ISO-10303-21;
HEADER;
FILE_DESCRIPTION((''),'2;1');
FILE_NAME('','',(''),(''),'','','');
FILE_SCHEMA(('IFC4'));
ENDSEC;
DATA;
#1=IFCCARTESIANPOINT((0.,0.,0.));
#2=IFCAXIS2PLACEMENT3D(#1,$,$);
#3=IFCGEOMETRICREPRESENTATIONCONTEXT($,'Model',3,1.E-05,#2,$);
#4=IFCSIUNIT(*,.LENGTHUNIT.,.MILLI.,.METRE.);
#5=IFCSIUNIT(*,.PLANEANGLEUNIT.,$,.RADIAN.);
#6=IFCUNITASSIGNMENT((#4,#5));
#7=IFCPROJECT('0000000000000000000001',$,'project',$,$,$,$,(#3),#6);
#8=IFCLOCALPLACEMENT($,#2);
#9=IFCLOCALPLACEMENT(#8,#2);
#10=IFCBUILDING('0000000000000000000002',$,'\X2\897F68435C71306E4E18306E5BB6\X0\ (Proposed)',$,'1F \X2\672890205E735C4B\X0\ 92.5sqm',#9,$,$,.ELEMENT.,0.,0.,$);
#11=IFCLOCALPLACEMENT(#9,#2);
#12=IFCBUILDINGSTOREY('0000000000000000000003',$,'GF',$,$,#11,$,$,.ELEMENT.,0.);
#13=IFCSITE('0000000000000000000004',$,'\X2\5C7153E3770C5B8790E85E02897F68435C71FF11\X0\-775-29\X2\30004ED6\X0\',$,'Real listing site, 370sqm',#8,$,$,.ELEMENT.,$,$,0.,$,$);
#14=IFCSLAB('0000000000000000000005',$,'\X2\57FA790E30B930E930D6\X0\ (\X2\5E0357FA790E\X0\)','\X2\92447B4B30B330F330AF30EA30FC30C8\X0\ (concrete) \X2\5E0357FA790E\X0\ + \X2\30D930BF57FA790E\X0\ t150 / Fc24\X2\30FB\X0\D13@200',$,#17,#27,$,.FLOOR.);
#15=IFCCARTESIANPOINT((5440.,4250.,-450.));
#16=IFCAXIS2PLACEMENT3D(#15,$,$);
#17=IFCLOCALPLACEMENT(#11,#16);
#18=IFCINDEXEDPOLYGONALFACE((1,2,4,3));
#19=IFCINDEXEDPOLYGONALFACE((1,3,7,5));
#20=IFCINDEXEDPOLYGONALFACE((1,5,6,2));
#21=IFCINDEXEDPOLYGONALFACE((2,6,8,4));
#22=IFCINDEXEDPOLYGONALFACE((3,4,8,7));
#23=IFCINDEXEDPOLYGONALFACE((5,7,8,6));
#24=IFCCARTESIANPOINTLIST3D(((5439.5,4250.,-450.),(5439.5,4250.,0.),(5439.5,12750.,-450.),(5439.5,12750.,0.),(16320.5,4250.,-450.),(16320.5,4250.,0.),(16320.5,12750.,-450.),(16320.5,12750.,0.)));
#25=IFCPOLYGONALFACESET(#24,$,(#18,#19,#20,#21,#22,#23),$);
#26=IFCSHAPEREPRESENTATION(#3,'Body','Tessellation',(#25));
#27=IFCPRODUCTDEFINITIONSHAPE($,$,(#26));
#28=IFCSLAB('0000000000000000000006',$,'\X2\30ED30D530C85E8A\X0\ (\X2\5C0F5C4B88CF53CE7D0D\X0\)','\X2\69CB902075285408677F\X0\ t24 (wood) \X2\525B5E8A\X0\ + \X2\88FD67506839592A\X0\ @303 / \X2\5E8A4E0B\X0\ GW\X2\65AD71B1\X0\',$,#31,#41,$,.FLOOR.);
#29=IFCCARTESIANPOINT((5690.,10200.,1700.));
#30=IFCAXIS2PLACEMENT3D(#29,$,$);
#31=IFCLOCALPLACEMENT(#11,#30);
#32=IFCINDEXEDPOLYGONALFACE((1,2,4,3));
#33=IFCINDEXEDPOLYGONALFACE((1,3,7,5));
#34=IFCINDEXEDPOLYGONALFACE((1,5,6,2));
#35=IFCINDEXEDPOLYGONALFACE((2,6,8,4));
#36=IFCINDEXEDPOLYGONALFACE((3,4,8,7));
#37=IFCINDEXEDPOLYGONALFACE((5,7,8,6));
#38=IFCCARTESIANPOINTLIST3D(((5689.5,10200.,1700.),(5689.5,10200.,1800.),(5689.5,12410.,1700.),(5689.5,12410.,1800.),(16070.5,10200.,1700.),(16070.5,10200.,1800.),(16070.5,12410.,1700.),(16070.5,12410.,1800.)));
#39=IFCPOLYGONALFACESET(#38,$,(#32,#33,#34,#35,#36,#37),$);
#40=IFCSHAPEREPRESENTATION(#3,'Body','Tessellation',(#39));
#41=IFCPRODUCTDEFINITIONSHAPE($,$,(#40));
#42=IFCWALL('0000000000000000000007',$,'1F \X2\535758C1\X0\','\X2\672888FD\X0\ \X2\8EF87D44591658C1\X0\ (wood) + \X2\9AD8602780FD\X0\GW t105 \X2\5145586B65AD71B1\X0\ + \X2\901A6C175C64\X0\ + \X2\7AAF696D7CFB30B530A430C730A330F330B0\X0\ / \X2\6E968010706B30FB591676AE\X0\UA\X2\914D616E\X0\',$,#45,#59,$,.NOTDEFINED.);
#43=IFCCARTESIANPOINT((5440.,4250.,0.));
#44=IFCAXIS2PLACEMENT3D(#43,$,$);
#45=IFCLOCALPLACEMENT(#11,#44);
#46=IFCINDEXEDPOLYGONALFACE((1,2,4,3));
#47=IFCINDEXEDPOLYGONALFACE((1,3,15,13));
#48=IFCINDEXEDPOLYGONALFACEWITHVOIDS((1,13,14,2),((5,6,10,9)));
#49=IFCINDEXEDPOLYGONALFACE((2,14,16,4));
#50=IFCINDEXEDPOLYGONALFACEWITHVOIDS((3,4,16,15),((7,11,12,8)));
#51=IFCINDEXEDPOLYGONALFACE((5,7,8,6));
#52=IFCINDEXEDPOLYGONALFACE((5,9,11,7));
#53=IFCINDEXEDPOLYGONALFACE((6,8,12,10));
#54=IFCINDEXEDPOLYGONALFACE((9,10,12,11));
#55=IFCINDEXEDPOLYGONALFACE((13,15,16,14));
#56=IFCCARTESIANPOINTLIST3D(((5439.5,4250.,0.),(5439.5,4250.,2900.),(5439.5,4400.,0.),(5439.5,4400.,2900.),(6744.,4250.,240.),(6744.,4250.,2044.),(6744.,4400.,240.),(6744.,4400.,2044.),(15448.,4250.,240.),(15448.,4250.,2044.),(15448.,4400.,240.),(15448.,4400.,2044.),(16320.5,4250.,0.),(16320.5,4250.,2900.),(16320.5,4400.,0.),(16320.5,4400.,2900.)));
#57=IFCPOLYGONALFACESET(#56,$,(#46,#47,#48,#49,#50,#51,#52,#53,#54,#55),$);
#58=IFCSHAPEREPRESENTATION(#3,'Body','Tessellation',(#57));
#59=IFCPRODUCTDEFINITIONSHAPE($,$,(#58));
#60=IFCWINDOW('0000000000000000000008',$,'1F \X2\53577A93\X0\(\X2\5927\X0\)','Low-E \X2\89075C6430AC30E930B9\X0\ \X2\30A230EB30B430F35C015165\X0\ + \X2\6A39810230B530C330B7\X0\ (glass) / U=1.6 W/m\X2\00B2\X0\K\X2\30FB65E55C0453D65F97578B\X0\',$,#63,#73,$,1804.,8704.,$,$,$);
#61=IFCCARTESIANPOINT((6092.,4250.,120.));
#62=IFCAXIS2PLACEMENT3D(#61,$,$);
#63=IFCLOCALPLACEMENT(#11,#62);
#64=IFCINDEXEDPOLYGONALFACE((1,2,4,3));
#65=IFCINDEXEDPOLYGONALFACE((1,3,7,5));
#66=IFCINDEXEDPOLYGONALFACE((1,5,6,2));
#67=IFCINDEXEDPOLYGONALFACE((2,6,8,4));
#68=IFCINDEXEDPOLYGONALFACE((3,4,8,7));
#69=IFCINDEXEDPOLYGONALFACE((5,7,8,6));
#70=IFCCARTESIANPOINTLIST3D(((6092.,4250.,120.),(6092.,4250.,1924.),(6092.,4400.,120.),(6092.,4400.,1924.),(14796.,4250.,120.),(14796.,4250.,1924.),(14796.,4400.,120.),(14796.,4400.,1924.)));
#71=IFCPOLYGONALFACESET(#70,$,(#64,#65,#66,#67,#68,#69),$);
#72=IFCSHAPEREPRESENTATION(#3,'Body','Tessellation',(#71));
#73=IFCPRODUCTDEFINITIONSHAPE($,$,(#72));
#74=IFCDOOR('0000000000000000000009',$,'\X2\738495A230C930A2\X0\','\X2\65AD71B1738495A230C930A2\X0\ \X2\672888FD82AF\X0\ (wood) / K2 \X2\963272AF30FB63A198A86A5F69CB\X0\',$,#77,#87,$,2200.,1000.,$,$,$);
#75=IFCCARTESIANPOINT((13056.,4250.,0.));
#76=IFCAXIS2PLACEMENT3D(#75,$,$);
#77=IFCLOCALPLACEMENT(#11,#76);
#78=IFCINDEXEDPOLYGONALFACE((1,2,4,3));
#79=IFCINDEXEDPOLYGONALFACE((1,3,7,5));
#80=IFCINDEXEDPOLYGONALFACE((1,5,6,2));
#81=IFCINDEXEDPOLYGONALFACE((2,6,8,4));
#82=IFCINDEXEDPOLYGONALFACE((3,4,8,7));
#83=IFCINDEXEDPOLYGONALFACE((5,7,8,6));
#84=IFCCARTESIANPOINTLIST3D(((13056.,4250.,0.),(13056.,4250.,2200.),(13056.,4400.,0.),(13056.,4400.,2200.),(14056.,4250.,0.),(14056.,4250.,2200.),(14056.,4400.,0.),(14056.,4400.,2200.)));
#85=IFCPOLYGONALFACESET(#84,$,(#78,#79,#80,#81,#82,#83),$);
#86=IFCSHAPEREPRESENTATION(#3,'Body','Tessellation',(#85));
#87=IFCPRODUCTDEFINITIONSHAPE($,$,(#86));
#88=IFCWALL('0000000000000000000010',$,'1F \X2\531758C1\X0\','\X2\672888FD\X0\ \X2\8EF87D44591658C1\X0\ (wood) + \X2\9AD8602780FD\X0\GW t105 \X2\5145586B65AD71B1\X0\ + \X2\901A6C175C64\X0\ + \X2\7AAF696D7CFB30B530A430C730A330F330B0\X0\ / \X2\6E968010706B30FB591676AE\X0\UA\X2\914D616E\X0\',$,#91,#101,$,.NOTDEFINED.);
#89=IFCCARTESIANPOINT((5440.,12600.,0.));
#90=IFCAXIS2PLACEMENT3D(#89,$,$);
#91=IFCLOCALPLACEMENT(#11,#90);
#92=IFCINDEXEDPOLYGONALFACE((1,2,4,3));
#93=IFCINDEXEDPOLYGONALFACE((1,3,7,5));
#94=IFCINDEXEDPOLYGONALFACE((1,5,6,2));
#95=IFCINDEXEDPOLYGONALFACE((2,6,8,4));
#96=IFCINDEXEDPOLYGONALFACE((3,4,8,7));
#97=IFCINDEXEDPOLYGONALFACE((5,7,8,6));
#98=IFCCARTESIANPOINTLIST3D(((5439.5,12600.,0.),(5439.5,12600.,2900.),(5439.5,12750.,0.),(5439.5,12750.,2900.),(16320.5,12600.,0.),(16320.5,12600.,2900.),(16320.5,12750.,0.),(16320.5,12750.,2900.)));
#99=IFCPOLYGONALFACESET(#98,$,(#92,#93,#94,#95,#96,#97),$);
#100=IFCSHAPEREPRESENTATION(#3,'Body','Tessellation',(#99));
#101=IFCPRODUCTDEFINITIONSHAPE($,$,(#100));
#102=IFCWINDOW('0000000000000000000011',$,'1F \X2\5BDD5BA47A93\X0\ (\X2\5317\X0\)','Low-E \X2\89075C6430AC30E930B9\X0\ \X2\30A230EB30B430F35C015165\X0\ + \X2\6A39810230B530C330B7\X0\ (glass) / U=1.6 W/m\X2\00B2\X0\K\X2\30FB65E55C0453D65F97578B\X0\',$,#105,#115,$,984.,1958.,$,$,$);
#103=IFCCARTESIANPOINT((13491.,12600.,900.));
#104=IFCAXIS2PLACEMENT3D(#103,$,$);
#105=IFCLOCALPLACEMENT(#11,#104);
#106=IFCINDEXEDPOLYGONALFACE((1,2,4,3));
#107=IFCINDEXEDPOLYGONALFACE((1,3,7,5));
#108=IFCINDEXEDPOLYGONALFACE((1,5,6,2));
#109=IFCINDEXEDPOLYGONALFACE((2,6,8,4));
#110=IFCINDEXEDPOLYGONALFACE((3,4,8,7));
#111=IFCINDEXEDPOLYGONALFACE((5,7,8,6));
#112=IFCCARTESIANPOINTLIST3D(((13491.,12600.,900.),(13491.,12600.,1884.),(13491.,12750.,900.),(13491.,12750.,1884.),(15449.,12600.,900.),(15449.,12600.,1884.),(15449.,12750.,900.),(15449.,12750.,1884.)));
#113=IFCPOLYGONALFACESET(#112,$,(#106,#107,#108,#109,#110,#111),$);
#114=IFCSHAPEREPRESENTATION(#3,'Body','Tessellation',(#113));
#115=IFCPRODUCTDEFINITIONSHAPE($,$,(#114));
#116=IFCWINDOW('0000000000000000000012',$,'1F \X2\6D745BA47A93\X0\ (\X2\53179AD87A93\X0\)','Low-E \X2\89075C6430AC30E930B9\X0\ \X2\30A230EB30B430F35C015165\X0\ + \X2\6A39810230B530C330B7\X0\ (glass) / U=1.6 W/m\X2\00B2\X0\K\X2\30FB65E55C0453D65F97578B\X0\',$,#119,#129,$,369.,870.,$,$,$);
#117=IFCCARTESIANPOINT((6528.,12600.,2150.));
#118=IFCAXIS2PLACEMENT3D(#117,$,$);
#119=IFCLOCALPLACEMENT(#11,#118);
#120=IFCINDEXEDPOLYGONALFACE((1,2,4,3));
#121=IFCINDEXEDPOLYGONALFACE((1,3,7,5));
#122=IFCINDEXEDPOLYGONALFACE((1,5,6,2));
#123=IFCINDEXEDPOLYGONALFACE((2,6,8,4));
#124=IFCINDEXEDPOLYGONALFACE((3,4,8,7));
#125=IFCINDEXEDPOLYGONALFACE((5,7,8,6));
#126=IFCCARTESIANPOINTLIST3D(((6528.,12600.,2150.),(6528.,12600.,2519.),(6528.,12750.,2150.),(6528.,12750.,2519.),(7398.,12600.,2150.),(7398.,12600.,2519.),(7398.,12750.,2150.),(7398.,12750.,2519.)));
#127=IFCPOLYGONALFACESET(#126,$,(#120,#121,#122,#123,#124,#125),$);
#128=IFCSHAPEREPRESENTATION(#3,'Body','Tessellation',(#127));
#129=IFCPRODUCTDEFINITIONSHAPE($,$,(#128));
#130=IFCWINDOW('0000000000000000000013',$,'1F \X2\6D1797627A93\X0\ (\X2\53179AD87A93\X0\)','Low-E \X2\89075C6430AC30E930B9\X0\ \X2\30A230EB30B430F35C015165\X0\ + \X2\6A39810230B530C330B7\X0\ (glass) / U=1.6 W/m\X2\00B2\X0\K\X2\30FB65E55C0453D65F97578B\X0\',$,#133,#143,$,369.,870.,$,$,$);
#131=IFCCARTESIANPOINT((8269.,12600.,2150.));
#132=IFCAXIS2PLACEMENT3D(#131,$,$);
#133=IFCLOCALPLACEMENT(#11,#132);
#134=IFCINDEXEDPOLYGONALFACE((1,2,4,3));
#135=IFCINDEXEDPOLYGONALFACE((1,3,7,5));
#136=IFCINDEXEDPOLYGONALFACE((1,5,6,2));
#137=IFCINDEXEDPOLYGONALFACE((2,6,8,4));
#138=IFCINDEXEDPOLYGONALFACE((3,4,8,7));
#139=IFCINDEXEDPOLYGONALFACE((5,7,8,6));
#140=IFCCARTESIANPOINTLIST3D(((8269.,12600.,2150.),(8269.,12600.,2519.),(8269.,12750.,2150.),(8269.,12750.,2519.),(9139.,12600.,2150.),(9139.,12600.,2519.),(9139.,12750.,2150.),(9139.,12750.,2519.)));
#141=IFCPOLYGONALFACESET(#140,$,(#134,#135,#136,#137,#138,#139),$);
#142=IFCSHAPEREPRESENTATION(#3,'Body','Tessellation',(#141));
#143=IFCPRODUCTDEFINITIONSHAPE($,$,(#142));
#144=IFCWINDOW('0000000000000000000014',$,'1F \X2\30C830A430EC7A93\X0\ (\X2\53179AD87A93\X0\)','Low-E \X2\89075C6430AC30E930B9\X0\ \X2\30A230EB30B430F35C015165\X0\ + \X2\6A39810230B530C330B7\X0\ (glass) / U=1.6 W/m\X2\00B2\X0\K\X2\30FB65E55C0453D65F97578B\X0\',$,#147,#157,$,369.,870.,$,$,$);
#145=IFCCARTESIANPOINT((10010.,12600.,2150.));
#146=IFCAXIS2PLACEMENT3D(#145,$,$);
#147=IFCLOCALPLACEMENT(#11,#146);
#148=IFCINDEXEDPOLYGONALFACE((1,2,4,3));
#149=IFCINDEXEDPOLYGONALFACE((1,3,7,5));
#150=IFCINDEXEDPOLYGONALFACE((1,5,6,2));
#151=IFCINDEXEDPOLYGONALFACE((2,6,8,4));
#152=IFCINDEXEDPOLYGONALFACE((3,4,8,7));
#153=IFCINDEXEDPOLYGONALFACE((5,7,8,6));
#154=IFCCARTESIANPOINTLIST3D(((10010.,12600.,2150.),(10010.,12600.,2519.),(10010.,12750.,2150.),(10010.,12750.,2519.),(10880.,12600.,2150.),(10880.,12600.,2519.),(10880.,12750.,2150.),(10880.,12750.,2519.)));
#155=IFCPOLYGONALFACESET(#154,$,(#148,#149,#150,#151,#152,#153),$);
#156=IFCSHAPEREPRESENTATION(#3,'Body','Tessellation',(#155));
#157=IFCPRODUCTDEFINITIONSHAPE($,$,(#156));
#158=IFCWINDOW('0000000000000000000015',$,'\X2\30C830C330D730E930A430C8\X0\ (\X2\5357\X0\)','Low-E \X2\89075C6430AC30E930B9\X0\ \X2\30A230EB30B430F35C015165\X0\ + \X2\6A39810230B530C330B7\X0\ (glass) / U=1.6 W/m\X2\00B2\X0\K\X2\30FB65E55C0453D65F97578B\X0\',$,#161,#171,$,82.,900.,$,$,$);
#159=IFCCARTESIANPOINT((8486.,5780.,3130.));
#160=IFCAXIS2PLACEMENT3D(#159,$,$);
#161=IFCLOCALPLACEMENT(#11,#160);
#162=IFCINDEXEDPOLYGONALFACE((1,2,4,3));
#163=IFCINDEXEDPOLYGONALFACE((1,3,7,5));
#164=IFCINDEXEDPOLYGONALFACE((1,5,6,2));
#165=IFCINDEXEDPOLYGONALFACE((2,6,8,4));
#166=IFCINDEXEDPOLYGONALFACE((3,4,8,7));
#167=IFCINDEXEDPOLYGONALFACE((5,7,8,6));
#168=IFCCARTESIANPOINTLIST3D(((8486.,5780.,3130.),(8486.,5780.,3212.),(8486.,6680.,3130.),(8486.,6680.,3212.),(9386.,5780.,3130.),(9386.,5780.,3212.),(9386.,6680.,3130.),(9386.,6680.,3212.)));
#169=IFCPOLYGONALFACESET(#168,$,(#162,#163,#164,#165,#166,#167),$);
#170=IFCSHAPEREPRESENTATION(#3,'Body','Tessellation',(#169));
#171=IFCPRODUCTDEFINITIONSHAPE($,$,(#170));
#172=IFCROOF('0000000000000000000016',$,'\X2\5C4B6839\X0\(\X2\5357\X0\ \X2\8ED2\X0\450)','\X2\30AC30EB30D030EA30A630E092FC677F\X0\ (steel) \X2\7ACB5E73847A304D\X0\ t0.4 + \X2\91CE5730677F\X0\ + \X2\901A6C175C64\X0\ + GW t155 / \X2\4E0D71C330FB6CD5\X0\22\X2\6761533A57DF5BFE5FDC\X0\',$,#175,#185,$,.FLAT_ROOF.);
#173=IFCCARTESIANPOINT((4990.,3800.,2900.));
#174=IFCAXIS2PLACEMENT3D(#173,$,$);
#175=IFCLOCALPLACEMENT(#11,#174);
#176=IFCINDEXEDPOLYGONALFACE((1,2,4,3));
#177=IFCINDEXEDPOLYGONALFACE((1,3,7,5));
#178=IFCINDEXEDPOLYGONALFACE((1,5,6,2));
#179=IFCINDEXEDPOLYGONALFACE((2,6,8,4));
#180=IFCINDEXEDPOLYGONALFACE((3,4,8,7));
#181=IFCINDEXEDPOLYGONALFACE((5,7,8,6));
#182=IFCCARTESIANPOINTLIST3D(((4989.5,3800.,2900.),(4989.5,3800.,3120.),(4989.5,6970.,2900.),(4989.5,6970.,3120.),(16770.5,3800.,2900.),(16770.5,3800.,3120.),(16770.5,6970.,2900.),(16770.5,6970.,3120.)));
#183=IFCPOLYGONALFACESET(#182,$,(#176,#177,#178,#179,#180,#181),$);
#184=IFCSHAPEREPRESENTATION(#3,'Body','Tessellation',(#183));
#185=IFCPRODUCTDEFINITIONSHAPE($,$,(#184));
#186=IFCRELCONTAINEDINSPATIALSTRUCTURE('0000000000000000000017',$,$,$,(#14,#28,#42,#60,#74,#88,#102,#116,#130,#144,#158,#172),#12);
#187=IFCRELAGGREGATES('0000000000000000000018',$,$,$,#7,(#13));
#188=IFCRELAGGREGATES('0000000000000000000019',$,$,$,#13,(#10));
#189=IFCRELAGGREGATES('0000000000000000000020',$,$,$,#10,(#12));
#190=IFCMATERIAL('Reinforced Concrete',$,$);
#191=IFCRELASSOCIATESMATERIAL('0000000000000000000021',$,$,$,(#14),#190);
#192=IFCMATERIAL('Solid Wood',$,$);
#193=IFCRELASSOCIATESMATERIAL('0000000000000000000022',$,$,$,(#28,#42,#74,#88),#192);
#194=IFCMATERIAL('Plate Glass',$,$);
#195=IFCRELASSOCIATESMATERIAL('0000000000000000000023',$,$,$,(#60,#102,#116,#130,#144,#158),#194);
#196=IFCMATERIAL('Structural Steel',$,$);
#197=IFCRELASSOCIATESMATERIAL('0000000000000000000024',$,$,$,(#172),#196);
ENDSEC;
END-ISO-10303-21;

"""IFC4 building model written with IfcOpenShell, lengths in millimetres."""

from ifc_helpers import new_model, si_unit, frame, frame_2d, origin, place, context, project, spatial, rectangle, extrude, material, element, fill, save


model = new_model("IFC4")

# Units and contexts
model_context = context("Model", 3, precision=1e-05, world=origin())
ifc_project = project(units=[si_unit("LENGTHUNIT", "METRE", prefix="MILLI"), si_unit("PLANEANGLEUNIT", "RADIAN")], contexts=[model_context])

# Site, building, storey
site_placement = place(None, origin())
site = spatial("IfcSite", under=ifc_project, at=site_placement, Name="山口県宇部市西桃山１-775-29　他", ObjectType="Real listing site, 370sqm", CompositionType="ELEMENT", RefElevation=0.0)
building_placement = place(site_placement, origin())
building = spatial("IfcBuilding", under=site, at=building_placement, Name="西桃山の丘の家 (Proposed)", ObjectType="1F 木造平屋 92.5sqm", CompositionType="ELEMENT", ElevationOfRefHeight=0.0, ElevationOfTerrain=0.0)
storey_placement = place(building_placement, origin())
storey = spatial("IfcBuildingStorey", under=building, at=storey_placement, Name="GF", CompositionType="ELEMENT", Elevation=0.0)

# Slabs
ifc_material_1 = material(Name="Reinforced Concrete")
slab_1_placement = place(storey_placement, frame((5440.0, 4250.0, -450.0)))
element("IfcSlab", 1, at=slab_1_placement, inside=storey, material=ifc_material_1, Name="基礎スラブ (布基礎)", Description="鉄筋コンクリート (concrete) 布基礎 + ベタ基礎 t150 / Fc24・D13@200", PredefinedType="FLOOR", context=model_context, shape_type="SweptSolid", body=[
    extrude(rectangle(XDim=10881.0, YDim=8500.0, at=frame_2d((5440.0, 4250.0))), frame((5440.0, 4250.0, -450.0)), (0.0, 0.0, 1.0), 450.0),
])
ifc_material_2 = material(Name="Solid Wood")
slab_2_placement = place(storey_placement, frame((5690.0, 10200.0, 1700.0)))
element("IfcSlab", 2, at=slab_2_placement, inside=storey, material=ifc_material_2, Name="ロフト床 (小屋裏収納)", Description="構造用合板 t24 (wood) 剛床 + 製材根太 @303 / 床下 GW断熱", PredefinedType="FLOOR", context=model_context, shape_type="SweptSolid", body=[
    extrude(rectangle(XDim=10381.0, YDim=2210.0, at=frame_2d((5190.0, 1105.0))), frame((5690.0, 10200.0, 1700.0)), (0.0, 0.0, 1.0), 100.0),
])

# Wall, openings, window, door
wall_1_placement = place(storey_placement, frame((5440.0, 4250.0, 0.0)))
wall_1 = element("IfcWall", 3, at=wall_1_placement, inside=storey, material=ifc_material_2, Name="1F 南壁", Description="木製 軸組外壁 (wood) + 高性能GW t105 充填断熱 + 通気層 + 窯業系サイディング / 準耐火・外皮UA配慮", PredefinedType="NOTDEFINED", context=model_context, shape_type="SweptSolid", body=[
    extrude(rectangle(XDim=10881.0, YDim=150.0, at=frame_2d((5440.0, 75.0))), frame((5440.0, 4250.0, 0.0)), (0.0, 0.0, 1.0), 2900.0),
])
opening_1_placement = place(storey_placement, frame((6092.0, 4250.0, 120.0)))
opening_1 = element("IfcOpeningElement", 4, at=opening_1_placement, cuts=wall_1, PredefinedType="NOTDEFINED", context=model_context, shape_type="SweptSolid", body=[
    extrude(rectangle(XDim=8704.0, YDim=150.0, at=frame_2d((4352.0, 75.0))), frame((6092.0, 4250.0, 120.0)), (0.0, 0.0, 1.0), 1804.0),
])
opening_2_placement = place(storey_placement, frame((13056.0, 4250.0, 0.0)))
opening_2 = element("IfcOpeningElement", 5, at=opening_2_placement, cuts=wall_1, PredefinedType="NOTDEFINED", context=model_context, shape_type="SweptSolid", body=[
    extrude(rectangle(XDim=1000.0, YDim=150.0, at=frame_2d((500.0, 75.0))), frame((13056.0, 4250.0, 0.0)), (0.0, 0.0, 1.0), 2200.0),
])
ifc_material_3 = material(Name="Plate Glass")
window_1_placement = place(storey_placement, frame((6092.0, 4250.0, 120.0)))
window_1 = element("IfcWindow", 6, at=window_1_placement, inside=storey, material=ifc_material_3, Name="1F 南窓(大)", Description="Low-E 複層ガラス アルゴン封入 + 樹脂サッシ (glass) / U=1.6 W/m²K・日射取得型", OverallHeight=1804.0, OverallWidth=8704.0, context=model_context, shape_type="SweptSolid", body=[
    extrude(rectangle(XDim=8704.0, YDim=150.0, at=frame_2d((4352.0, 75.0))), frame((6092.0, 4250.0, 120.0)), (0.0, 0.0, 1.0), 1804.0),
])
fill(opening_1, window_1)
door_1_placement = place(storey_placement, frame((13056.0, 4250.0, 0.0)))
door_1 = element("IfcDoor", 7, at=door_1_placement, inside=storey, material=ifc_material_2, Name="玄関ドア", Description="断熱玄関ドア 木製芯 (wood) / K2 防犯・採風機構", OverallHeight=2200.0, OverallWidth=1000.0, context=model_context, shape_type="SweptSolid", body=[
    extrude(rectangle(XDim=1000.0, YDim=150.0, at=frame_2d((500.0, 75.0))), frame((13056.0, 4250.0, 0.0)), (0.0, 0.0, 1.0), 2200.0),
])
fill(opening_2, door_1)

# Wall, openings, windows
wall_2_placement = place(storey_placement, frame((5440.0, 12600.0, 0.0)))
wall_2 = element("IfcWall", 8, at=wall_2_placement, inside=storey, material=ifc_material_2, Name="1F 北壁", Description="木製 軸組外壁 (wood) + 高性能GW t105 充填断熱 + 通気層 + 窯業系サイディング / 準耐火・外皮UA配慮", PredefinedType="NOTDEFINED", context=model_context, shape_type="SweptSolid", body=[
    extrude(rectangle(XDim=10881.0, YDim=150.0, at=frame_2d((5440.0, 75.0))), frame((5440.0, 12600.0, 0.0)), (0.0, 0.0, 1.0), 2900.0),
])
opening_3_placement = place(storey_placement, frame((13491.0, 12600.0, 900.0)))
opening_3 = element("IfcOpeningElement", 9, at=opening_3_placement, cuts=wall_2, PredefinedType="NOTDEFINED", context=model_context, shape_type="SweptSolid", body=[
    extrude(rectangle(XDim=1958.0, YDim=150.0, at=frame_2d((979.0, 75.0))), frame((13491.0, 12600.0, 900.0)), (0.0, 0.0, 1.0), 984.0),
])
opening_4_placement = place(storey_placement, frame((6528.0, 12600.0, 2150.0)))
opening_4 = element("IfcOpeningElement", 10, at=opening_4_placement, cuts=wall_2, PredefinedType="NOTDEFINED", context=model_context, shape_type="SweptSolid", body=[
    extrude(rectangle(XDim=870.0, YDim=150.0, at=frame_2d((435.0, 75.0))), frame((6528.0, 12600.0, 2150.0)), (0.0, 0.0, 1.0), 369.0),
])
opening_5_placement = place(storey_placement, frame((8269.0, 12600.0, 2150.0)))
opening_5 = element("IfcOpeningElement", 11, at=opening_5_placement, cuts=wall_2, PredefinedType="NOTDEFINED", context=model_context, shape_type="SweptSolid", body=[
    extrude(rectangle(XDim=870.0, YDim=150.0, at=frame_2d((435.0, 75.0))), frame((8269.0, 12600.0, 2150.0)), (0.0, 0.0, 1.0), 369.0),
])
opening_6_placement = place(storey_placement, frame((10010.0, 12600.0, 2150.0)))
opening_6 = element("IfcOpeningElement", 12, at=opening_6_placement, cuts=wall_2, PredefinedType="NOTDEFINED", context=model_context, shape_type="SweptSolid", body=[
    extrude(rectangle(XDim=870.0, YDim=150.0, at=frame_2d((435.0, 75.0))), frame((10010.0, 12600.0, 2150.0)), (0.0, 0.0, 1.0), 369.0),
])
window_2_placement = place(storey_placement, frame((13491.0, 12600.0, 900.0)))
window_2 = element("IfcWindow", 13, at=window_2_placement, inside=storey, material=ifc_material_3, Name="1F 寝室窓 (北)", Description="Low-E 複層ガラス アルゴン封入 + 樹脂サッシ (glass) / U=1.6 W/m²K・日射取得型", OverallHeight=984.0, OverallWidth=1958.0, context=model_context, shape_type="SweptSolid", body=[
    extrude(rectangle(XDim=1958.0, YDim=150.0, at=frame_2d((979.0, 75.0))), frame((13491.0, 12600.0, 900.0)), (0.0, 0.0, 1.0), 984.0),
])
fill(opening_3, window_2)
window_3_placement = place(storey_placement, frame((6528.0, 12600.0, 2150.0)))
window_3 = element("IfcWindow", 14, at=window_3_placement, inside=storey, material=ifc_material_3, Name="1F 浴室窓 (北高窓)", Description="Low-E 複層ガラス アルゴン封入 + 樹脂サッシ (glass) / U=1.6 W/m²K・日射取得型", OverallHeight=369.0, OverallWidth=870.0, context=model_context, shape_type="SweptSolid", body=[
    extrude(rectangle(XDim=870.0, YDim=150.0, at=frame_2d((435.0, 75.0))), frame((6528.0, 12600.0, 2150.0)), (0.0, 0.0, 1.0), 369.0),
])
fill(opening_4, window_3)
window_4_placement = place(storey_placement, frame((8269.0, 12600.0, 2150.0)))
window_4 = element("IfcWindow", 15, at=window_4_placement, inside=storey, material=ifc_material_3, Name="1F 洗面窓 (北高窓)", Description="Low-E 複層ガラス アルゴン封入 + 樹脂サッシ (glass) / U=1.6 W/m²K・日射取得型", OverallHeight=369.0, OverallWidth=870.0, context=model_context, shape_type="SweptSolid", body=[
    extrude(rectangle(XDim=870.0, YDim=150.0, at=frame_2d((435.0, 75.0))), frame((8269.0, 12600.0, 2150.0)), (0.0, 0.0, 1.0), 369.0),
])
fill(opening_5, window_4)
window_5_placement = place(storey_placement, frame((10010.0, 12600.0, 2150.0)))
window_5 = element("IfcWindow", 16, at=window_5_placement, inside=storey, material=ifc_material_3, Name="1F トイレ窓 (北高窓)", Description="Low-E 複層ガラス アルゴン封入 + 樹脂サッシ (glass) / U=1.6 W/m²K・日射取得型", OverallHeight=369.0, OverallWidth=870.0, context=model_context, shape_type="SweptSolid", body=[
    extrude(rectangle(XDim=870.0, YDim=150.0, at=frame_2d((435.0, 75.0))), frame((10010.0, 12600.0, 2150.0)), (0.0, 0.0, 1.0), 369.0),
])
fill(opening_6, window_5)

# Window
window_6_placement = place(storey_placement, frame((8486.0, 5780.0, 3130.0)))
element("IfcWindow", 17, at=window_6_placement, inside=storey, material=ifc_material_3, Name="トップライト (南)", Description="Low-E 複層ガラス アルゴン封入 + 樹脂サッシ (glass) / U=1.6 W/m²K・日射取得型", OverallHeight=82.0, OverallWidth=900.0, context=model_context, shape_type="SweptSolid", body=[
    extrude(rectangle(XDim=900.0, YDim=900.0, at=frame_2d((450.0, 450.0))), frame((8486.0, 5780.0, 3130.0)), (0.0, 0.0, 1.0), 82.0),
])

# Roof
ifc_material_4 = material(Name="Structural Steel")
roof_1_placement = place(storey_placement, frame((4990.0, 3800.0, 2900.0)))
element("IfcRoof", 18, at=roof_1_placement, inside=storey, material=ifc_material_4, Name="屋根(南 軒450)", Description="ガルバリウム鋼板 (steel) 立平葺き t0.4 + 野地板 + 通気層 + GW t155 / 不燃・法22条区域対応", PredefinedType="FLAT_ROOF", context=model_context, shape_type="SweptSolid", body=[
    extrude(rectangle(XDim=11781.0, YDim=3170.0, at=frame_2d((5890.0, 1585.0))), frame((4990.0, 3800.0, 2900.0)), (0.0, 0.0, 1.0), 220.0),
])

save(model, "model.ifc")
